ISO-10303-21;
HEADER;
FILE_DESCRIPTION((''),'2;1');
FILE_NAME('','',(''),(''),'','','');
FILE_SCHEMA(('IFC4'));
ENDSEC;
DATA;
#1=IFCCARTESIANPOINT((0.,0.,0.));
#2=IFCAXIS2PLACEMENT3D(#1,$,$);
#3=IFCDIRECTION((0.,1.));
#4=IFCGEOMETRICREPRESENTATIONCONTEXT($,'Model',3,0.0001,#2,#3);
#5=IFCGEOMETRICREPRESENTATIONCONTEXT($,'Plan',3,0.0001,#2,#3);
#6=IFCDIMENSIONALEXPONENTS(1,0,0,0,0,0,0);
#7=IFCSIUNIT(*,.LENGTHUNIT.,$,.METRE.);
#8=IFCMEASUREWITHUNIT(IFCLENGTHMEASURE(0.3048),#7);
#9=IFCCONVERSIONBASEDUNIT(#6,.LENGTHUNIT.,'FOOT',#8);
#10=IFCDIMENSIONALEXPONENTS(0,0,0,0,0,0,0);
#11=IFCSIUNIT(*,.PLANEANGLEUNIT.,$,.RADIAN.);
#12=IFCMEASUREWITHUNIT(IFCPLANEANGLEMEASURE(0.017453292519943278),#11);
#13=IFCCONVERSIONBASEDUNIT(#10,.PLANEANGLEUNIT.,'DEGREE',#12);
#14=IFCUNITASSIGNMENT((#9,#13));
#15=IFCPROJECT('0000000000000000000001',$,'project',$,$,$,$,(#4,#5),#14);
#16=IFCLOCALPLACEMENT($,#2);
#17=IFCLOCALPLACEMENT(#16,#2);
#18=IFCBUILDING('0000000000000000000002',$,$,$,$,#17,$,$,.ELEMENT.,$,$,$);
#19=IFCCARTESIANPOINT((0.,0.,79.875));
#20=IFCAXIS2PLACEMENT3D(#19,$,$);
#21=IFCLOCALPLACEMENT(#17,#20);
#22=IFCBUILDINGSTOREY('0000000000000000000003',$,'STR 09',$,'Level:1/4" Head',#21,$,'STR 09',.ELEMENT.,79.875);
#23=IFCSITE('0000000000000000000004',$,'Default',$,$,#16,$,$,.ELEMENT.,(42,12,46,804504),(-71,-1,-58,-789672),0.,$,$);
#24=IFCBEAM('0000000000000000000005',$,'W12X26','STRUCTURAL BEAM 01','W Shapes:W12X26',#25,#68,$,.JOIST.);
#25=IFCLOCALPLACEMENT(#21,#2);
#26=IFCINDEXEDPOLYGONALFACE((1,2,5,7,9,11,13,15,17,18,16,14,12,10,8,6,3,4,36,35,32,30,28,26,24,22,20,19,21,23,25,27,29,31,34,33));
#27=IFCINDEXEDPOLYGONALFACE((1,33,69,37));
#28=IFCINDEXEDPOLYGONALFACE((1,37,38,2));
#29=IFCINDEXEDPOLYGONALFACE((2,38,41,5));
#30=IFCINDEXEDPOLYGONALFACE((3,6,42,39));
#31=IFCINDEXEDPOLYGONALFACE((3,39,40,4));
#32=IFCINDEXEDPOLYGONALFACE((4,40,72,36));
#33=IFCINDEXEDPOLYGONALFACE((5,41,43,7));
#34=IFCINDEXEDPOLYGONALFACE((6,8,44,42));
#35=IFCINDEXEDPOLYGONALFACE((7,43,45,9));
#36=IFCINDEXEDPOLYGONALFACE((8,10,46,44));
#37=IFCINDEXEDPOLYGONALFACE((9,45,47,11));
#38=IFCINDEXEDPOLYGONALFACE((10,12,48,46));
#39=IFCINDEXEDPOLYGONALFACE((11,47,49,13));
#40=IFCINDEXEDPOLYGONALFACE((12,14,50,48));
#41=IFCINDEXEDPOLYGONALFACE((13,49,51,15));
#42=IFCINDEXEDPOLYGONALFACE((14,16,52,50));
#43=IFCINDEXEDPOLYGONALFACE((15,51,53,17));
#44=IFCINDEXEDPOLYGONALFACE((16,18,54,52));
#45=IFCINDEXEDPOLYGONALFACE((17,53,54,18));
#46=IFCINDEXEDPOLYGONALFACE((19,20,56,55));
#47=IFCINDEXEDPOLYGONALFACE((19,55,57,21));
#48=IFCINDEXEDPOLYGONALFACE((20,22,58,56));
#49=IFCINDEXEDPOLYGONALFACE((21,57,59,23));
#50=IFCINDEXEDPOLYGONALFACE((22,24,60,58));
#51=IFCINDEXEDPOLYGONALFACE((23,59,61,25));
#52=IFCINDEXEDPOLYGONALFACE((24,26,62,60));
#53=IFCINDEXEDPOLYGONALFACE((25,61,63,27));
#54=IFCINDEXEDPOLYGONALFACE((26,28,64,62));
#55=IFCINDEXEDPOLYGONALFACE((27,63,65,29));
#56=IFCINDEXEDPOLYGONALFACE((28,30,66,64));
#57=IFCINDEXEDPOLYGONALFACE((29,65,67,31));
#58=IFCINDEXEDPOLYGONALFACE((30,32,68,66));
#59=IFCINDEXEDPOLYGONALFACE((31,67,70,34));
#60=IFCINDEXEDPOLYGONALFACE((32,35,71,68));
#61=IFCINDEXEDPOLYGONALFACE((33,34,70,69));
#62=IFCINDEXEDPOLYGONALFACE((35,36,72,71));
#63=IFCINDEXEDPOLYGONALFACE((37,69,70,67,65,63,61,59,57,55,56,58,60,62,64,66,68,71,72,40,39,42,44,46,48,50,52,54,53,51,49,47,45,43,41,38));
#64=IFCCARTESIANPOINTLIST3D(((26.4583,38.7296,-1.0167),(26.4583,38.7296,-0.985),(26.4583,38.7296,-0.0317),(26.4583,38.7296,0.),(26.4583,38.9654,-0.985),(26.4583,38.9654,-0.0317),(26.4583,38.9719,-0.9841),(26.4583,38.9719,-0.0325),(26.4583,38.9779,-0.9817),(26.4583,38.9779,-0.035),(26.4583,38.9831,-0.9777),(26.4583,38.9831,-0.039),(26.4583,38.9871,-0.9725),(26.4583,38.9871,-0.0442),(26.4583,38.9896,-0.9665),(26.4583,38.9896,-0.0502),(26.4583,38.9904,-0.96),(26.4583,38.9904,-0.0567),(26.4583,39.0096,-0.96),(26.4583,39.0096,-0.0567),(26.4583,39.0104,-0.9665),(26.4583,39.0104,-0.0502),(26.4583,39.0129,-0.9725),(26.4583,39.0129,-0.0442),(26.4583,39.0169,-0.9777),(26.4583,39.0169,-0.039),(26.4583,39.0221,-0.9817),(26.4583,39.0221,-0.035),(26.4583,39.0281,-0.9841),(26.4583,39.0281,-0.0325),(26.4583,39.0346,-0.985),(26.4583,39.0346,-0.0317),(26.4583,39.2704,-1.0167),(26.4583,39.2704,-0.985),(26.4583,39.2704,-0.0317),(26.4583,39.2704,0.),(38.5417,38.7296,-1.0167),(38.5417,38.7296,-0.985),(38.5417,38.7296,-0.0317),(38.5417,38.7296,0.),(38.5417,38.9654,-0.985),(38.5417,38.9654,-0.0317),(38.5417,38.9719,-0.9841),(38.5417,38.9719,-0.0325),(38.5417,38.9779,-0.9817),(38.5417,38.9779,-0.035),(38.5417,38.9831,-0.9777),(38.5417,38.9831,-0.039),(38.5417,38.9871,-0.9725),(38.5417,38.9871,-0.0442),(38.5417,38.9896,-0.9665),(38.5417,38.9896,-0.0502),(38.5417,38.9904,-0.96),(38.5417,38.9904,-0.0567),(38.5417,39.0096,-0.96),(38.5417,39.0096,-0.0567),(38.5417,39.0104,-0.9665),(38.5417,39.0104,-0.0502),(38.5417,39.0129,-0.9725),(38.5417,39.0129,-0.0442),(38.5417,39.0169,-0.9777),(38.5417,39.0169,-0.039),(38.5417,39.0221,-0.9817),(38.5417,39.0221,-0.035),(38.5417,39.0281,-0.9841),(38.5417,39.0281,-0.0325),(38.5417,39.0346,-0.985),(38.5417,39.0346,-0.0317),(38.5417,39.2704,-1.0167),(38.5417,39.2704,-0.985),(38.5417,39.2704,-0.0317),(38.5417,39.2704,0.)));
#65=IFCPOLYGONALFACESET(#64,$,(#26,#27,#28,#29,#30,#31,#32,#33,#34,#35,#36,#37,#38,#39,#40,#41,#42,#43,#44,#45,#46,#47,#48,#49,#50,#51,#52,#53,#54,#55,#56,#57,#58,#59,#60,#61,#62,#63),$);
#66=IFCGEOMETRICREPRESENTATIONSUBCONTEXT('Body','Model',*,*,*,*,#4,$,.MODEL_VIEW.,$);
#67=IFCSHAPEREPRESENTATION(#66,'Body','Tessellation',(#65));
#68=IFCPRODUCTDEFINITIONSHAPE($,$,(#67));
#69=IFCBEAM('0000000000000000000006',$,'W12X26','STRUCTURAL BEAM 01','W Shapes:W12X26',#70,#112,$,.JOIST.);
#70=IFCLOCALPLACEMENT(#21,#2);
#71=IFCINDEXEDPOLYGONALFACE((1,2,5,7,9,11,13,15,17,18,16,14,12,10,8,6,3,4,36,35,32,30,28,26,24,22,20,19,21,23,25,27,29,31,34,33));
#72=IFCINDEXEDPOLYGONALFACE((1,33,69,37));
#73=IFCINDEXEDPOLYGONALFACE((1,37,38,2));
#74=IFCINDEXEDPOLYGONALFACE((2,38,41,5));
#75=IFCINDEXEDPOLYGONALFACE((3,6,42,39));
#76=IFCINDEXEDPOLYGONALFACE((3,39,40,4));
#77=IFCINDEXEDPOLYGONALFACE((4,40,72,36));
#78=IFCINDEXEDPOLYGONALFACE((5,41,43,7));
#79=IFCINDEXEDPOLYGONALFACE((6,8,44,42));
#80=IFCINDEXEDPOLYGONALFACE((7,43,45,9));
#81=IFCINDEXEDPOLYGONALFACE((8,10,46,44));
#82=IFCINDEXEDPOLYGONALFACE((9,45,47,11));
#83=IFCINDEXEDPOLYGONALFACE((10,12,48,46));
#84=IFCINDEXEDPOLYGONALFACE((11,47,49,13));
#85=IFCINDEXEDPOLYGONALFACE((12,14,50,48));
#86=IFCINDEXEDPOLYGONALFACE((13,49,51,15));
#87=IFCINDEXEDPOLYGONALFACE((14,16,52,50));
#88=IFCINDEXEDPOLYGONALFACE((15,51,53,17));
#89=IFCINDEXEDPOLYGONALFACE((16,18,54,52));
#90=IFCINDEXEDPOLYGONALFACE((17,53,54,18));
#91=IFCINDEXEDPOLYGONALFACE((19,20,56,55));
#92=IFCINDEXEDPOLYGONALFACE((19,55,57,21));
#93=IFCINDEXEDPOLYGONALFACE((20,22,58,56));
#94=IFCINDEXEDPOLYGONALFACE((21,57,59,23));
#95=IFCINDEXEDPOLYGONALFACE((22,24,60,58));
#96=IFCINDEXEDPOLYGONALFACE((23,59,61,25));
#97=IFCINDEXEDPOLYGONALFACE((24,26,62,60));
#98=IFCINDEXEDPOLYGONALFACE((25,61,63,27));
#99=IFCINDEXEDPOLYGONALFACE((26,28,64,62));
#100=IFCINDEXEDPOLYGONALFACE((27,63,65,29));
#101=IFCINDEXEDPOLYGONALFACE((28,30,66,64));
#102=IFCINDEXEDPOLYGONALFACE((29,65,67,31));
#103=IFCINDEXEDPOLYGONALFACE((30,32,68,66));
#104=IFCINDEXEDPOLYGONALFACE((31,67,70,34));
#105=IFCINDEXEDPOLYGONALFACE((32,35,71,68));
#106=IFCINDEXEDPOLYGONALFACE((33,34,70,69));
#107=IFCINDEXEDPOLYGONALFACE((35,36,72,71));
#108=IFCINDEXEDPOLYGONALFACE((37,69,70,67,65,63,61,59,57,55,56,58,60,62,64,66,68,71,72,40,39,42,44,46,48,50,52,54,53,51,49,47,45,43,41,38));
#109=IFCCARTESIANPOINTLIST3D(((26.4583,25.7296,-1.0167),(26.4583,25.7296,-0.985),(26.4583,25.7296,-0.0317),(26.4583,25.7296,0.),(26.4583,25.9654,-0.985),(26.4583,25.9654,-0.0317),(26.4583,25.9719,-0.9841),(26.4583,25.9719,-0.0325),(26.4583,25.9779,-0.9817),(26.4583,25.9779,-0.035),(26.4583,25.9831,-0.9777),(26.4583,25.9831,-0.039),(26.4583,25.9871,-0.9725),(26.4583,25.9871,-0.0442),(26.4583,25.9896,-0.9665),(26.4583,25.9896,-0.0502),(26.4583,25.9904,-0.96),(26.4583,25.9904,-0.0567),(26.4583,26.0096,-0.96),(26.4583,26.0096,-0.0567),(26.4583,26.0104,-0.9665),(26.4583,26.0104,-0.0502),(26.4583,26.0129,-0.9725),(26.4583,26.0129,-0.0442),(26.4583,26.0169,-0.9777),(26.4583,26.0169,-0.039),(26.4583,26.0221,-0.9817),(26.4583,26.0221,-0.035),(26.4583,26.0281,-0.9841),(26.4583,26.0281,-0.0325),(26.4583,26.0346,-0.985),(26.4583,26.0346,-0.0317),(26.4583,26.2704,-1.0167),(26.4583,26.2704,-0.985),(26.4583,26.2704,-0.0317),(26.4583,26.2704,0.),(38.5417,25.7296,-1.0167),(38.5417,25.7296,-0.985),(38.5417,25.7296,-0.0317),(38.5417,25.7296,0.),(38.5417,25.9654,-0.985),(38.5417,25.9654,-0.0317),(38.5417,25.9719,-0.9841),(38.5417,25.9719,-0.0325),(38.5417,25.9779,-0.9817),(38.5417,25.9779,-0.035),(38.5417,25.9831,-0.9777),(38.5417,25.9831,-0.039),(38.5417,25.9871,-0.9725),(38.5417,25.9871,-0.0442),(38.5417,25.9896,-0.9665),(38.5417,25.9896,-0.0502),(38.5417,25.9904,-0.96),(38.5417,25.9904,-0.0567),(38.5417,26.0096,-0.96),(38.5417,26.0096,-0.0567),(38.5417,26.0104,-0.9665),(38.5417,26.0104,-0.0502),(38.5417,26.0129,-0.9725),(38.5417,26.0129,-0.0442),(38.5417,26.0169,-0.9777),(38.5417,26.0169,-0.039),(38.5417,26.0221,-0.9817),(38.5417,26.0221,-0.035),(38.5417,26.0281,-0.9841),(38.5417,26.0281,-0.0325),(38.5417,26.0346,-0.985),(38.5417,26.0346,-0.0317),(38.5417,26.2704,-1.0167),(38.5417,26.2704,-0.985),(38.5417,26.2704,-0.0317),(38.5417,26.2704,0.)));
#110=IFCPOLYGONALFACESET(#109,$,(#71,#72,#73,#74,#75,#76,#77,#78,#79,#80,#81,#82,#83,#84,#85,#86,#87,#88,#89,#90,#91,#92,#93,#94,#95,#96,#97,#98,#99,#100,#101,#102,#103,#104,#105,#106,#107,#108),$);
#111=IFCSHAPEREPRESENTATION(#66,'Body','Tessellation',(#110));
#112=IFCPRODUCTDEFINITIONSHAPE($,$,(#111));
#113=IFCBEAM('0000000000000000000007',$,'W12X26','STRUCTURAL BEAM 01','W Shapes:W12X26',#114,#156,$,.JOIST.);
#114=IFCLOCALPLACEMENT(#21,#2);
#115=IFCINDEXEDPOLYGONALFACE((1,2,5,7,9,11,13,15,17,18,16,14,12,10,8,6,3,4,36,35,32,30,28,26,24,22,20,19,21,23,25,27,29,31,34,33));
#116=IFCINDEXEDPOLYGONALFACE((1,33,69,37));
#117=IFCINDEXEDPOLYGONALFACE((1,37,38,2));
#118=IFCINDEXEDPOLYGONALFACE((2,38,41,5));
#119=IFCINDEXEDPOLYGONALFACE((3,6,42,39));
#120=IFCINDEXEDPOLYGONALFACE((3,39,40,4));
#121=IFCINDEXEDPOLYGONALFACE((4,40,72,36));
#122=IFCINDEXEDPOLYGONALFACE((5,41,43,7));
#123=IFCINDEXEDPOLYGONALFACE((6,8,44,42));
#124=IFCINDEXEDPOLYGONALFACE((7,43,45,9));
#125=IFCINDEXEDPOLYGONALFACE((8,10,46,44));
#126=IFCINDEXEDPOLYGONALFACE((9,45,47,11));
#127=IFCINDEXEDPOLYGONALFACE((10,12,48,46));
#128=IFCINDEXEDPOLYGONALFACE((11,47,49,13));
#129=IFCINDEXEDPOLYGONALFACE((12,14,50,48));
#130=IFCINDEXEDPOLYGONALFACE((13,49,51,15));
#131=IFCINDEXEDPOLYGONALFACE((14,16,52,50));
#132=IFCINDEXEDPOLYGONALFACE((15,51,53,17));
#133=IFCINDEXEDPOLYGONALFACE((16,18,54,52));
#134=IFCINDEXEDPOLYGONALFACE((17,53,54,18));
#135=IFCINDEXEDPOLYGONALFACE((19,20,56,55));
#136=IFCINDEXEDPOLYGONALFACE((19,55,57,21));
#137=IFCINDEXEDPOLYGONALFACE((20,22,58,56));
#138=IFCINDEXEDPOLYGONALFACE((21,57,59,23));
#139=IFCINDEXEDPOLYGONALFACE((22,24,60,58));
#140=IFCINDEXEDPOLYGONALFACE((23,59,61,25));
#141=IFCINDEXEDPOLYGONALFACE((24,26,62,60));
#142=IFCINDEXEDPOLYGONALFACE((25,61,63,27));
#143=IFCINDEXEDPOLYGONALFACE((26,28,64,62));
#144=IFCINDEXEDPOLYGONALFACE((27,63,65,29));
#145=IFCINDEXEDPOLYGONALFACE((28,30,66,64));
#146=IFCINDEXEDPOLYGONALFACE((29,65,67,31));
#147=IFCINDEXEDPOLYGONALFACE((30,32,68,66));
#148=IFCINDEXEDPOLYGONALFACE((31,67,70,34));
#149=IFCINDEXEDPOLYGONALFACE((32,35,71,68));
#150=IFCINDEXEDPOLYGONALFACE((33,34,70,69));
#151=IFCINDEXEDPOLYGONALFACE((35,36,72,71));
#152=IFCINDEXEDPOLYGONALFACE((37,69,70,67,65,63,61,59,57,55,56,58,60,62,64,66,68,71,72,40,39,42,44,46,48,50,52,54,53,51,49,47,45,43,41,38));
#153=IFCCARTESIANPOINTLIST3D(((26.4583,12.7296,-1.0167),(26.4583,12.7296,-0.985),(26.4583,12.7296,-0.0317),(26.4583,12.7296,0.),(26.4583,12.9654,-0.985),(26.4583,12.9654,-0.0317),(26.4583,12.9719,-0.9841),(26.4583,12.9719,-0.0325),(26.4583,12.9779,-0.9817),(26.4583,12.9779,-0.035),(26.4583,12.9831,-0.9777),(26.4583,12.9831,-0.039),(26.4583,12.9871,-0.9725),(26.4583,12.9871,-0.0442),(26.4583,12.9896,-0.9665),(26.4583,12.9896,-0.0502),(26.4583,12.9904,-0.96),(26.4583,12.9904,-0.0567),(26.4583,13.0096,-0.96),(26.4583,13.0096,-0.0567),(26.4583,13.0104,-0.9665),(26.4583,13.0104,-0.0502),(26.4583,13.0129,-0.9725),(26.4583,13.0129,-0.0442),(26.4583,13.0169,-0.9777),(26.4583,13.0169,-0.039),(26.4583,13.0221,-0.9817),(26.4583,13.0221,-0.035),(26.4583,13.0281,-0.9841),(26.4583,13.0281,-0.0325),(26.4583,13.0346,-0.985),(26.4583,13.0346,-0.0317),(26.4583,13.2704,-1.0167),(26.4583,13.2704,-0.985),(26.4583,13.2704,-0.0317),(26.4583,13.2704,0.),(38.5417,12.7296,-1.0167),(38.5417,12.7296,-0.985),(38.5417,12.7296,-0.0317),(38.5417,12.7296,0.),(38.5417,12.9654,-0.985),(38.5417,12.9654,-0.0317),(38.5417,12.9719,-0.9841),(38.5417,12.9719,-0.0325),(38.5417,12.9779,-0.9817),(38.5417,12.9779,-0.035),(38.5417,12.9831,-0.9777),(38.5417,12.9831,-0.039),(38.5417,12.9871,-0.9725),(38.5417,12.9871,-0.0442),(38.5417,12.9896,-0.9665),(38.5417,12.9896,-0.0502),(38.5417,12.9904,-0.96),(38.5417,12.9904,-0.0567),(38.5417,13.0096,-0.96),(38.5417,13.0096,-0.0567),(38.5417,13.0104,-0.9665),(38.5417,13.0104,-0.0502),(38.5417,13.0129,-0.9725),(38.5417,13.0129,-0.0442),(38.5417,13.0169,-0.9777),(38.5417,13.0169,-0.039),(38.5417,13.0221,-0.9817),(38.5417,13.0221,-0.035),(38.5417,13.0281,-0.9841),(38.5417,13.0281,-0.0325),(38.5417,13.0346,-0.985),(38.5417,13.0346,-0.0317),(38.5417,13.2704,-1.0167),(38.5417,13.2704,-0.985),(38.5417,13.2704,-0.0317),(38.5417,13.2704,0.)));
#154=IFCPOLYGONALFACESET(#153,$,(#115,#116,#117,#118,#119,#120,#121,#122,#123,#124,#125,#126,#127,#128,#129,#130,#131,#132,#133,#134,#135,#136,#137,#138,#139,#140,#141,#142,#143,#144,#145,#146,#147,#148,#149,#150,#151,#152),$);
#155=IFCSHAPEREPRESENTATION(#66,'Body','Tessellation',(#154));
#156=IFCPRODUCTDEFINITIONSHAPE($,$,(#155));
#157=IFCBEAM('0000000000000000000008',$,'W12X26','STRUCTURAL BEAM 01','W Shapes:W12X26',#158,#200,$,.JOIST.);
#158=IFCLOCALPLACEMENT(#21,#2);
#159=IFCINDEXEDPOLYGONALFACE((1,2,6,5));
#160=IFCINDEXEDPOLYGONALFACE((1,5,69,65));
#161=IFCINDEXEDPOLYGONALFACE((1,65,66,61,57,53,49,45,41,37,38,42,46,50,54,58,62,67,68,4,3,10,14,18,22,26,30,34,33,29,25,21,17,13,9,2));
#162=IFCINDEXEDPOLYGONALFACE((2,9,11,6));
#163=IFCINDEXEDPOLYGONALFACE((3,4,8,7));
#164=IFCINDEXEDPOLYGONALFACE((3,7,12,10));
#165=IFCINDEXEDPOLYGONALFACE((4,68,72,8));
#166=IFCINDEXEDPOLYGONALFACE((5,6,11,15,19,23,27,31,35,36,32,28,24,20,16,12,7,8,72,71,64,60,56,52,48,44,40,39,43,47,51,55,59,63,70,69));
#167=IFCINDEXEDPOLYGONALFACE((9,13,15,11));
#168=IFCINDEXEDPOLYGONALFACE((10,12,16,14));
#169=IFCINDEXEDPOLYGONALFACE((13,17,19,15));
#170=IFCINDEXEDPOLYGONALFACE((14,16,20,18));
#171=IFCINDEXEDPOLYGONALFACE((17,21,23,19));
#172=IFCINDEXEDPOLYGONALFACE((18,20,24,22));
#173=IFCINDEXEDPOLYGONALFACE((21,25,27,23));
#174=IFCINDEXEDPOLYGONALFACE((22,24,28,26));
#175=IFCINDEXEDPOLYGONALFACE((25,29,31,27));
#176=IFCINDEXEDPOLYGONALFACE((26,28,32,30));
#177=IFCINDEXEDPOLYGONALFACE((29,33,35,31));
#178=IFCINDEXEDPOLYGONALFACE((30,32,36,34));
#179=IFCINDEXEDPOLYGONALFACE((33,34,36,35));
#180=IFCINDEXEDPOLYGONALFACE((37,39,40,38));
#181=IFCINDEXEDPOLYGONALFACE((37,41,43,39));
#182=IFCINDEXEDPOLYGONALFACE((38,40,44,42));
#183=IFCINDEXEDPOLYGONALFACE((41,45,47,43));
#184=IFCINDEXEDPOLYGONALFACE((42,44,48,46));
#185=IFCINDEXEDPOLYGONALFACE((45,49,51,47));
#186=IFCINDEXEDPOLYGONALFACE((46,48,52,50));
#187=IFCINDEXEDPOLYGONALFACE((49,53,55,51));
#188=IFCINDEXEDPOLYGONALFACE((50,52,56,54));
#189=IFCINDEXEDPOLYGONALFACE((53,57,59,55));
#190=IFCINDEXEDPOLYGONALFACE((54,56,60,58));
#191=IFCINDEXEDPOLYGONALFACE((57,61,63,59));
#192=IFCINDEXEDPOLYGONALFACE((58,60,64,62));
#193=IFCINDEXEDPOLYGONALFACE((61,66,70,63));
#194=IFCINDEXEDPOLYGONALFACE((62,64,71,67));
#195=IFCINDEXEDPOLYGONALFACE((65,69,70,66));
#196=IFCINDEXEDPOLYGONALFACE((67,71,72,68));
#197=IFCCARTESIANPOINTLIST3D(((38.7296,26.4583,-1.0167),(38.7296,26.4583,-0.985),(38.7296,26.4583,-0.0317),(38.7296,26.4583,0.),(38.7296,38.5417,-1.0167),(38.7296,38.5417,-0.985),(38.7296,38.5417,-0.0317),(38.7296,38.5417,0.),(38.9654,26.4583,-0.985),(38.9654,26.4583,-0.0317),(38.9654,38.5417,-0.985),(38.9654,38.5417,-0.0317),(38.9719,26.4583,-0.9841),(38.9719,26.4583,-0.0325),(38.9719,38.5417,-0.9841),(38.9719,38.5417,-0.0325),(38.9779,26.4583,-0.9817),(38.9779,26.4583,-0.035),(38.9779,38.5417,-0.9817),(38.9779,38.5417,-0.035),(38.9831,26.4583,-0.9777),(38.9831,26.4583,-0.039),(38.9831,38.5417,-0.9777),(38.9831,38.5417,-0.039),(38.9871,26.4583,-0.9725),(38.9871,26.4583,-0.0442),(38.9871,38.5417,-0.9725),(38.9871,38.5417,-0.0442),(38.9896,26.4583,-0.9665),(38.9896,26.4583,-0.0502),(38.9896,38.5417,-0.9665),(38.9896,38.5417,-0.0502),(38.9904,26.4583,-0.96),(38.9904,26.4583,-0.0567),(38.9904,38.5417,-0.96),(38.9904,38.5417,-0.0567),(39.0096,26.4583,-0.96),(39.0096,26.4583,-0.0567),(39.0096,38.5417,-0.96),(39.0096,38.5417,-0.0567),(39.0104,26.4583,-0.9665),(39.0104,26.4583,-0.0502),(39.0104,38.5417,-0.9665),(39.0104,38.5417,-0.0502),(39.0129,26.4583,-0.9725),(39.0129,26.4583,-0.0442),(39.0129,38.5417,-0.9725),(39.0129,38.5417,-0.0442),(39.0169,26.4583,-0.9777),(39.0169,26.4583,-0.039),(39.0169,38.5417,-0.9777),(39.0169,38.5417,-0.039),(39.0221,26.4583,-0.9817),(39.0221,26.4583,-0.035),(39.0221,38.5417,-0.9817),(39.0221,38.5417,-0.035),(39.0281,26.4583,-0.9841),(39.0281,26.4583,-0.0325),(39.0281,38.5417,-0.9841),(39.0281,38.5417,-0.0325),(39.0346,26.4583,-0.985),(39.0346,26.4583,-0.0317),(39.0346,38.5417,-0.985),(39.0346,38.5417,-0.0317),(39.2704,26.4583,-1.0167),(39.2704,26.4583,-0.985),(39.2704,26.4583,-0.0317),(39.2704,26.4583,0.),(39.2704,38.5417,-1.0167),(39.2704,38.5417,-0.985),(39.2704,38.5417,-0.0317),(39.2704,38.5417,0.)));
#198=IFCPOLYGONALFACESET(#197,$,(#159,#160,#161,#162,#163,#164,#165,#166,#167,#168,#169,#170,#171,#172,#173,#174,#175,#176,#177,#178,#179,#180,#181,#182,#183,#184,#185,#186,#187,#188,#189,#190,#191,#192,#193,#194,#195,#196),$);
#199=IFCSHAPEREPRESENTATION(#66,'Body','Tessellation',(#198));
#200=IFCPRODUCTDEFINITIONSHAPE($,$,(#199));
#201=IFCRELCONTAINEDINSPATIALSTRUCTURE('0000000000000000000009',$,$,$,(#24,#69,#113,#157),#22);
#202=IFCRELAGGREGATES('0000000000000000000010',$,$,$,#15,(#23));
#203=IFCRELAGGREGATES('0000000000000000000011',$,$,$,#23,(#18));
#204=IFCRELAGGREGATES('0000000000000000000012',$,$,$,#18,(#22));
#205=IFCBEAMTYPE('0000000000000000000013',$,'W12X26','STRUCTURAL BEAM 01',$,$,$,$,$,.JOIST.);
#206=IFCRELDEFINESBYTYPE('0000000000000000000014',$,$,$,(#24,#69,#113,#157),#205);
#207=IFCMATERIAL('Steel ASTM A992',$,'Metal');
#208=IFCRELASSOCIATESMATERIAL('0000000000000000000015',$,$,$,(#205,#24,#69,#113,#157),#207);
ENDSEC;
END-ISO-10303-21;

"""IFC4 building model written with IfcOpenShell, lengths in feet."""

from ifc_helpers import new_model, entity, si_unit, converted_unit, direction, frame, origin, place, context, subcontext, project, spatial, line, arc, indexed_curve, outline, extrude, source, transform, mapped, material, type_object, type_shapes, element, save


model = new_model("IFC4")

# Units and contexts
model_context = context("Model", 3, precision=0.0001, world=origin(), true_north=direction((0.0, 1.0)))
plan_context = context("Plan", 3, precision=0.0001, world=origin(), true_north=direction((0.0, 1.0)))
body_context = subcontext(model_context, "Body", "Model", "MODEL_VIEW")
ifc_project = project(units=[converted_unit("LENGTHUNIT", "FOOT", entity("IfcLengthMeasure", 0.3048), si_unit("LENGTHUNIT", "METRE"), dimensions=[1, 0, 0, 0, 0, 0, 0]), converted_unit("PLANEANGLEUNIT", "DEGREE", entity("IfcPlaneAngleMeasure", 0.017453292519943278), si_unit("PLANEANGLEUNIT", "RADIAN"), dimensions=[0, 0, 0, 0, 0, 0, 0])], contexts=[model_context, plan_context])

# Site, building, storey
site_placement = place(None, origin())
site = spatial("IfcSite", under=ifc_project, at=site_placement, Name="Default", CompositionType="ELEMENT", RefLatitude=(42, 12, 46, 804504), RefLongitude=(-71, -1, -58, -789672), RefElevation=0.0)
building_placement = place(site_placement, origin())
building = spatial("IfcBuilding", under=site, at=building_placement, CompositionType="ELEMENT")
storey_placement = place(building_placement, frame((0.0, 0.0, 79.875)))
storey = spatial("IfcBuildingStorey", under=building, at=storey_placement, Name="STR 09", ObjectType="Level:1/4\" Head", LongName="STR 09", CompositionType="ELEMENT", Elevation=79.875)

# Shared definitions
ifc_material = material(Name="Steel ASTM A992", Category="Metal")

# Beams
beam_type_1 = type_object("IfcBeamType", Name="W12X26", Description="STRUCTURAL BEAM 01", PredefinedType="JOIST", material=ifc_material)
shared_shape_1 = source(origin(), body_context, "Body", "SweptSolid", [
    extrude(outline(indexed_curve([(-0.2704, -0.4767), (-0.2704, -0.5083), (0.2704, -0.5083), (0.2704, -0.4767), (0.0346, -0.4767), (0.0169, -0.4693), (0.0096, -0.4517), (0.0096, 0.4517), (0.0169, 0.4693), (0.0346, 0.4767), (0.2704, 0.4767), (0.2704, 0.5083), (-0.2704, 0.5083), (-0.2704, 0.4767), (-0.0346, 0.4767), (-0.0169, 0.4693), (-0.0096, 0.4517), (-0.0096, -0.4517), (-0.0169, -0.4693), (-0.0346, -0.4767)], segments=[line(1, 2, 3, 4, 5), arc(5, 6, 7), line(7, 8), arc(8, 9, 10), line(10, 11, 12, 13, 14, 15), arc(15, 16, 17), line(17, 18), arc(18, 19, 20), line(20, 1)], self_intersect=False)), frame((-6.165, 0.0, 0.0), z_axis=(-1.0, 0.0, 0.0), x_axis=(0.0, -1.0, 0.0)), (0.0, 0.0, -1.0), 12.0833),
])
type_shapes(beam_type_1, [shared_shape_1])
for number, where, name in (
    (1, (32.6234, 39.0, -0.5083), "W12X26"),
    (2, (32.6234, 26.0, -0.5083), "W12X26"),
    (3, (32.6234, 13.0, -0.5083), "W12X26"),
):
    element("IfcBeam", number, at=place(storey_placement, frame(where)), inside=storey, type_object=beam_type_1, material=ifc_material, Name=name, Description="STRUCTURAL BEAM 01", ObjectType="W Shapes:W12X26", PredefinedType="JOIST", context=body_context, shape_type="MappedRepresentation", body=[
        mapped(shared_shape_1, transform((0.0, 0.0, 0.0), scale=1.0)),
    ])
for number, where, z_axis, x_axis, name in (
    (4, (39.0, 32.6234, -0.5083), (0.0, 0.0, 1.0), (0.0, 1.0, 0.0), "W12X26"),
):
    element("IfcBeam", number, at=place(storey_placement, frame(where, z_axis=z_axis, x_axis=x_axis)), inside=storey, type_object=beam_type_1, material=ifc_material, Name=name, Description="STRUCTURAL BEAM 01", ObjectType="W Shapes:W12X26", PredefinedType="JOIST", context=body_context, shape_type="MappedRepresentation", body=[
        mapped(shared_shape_1, transform((0.0, 0.0, 0.0), scale=1.0)),
    ])

save(model, "model.ifc")
